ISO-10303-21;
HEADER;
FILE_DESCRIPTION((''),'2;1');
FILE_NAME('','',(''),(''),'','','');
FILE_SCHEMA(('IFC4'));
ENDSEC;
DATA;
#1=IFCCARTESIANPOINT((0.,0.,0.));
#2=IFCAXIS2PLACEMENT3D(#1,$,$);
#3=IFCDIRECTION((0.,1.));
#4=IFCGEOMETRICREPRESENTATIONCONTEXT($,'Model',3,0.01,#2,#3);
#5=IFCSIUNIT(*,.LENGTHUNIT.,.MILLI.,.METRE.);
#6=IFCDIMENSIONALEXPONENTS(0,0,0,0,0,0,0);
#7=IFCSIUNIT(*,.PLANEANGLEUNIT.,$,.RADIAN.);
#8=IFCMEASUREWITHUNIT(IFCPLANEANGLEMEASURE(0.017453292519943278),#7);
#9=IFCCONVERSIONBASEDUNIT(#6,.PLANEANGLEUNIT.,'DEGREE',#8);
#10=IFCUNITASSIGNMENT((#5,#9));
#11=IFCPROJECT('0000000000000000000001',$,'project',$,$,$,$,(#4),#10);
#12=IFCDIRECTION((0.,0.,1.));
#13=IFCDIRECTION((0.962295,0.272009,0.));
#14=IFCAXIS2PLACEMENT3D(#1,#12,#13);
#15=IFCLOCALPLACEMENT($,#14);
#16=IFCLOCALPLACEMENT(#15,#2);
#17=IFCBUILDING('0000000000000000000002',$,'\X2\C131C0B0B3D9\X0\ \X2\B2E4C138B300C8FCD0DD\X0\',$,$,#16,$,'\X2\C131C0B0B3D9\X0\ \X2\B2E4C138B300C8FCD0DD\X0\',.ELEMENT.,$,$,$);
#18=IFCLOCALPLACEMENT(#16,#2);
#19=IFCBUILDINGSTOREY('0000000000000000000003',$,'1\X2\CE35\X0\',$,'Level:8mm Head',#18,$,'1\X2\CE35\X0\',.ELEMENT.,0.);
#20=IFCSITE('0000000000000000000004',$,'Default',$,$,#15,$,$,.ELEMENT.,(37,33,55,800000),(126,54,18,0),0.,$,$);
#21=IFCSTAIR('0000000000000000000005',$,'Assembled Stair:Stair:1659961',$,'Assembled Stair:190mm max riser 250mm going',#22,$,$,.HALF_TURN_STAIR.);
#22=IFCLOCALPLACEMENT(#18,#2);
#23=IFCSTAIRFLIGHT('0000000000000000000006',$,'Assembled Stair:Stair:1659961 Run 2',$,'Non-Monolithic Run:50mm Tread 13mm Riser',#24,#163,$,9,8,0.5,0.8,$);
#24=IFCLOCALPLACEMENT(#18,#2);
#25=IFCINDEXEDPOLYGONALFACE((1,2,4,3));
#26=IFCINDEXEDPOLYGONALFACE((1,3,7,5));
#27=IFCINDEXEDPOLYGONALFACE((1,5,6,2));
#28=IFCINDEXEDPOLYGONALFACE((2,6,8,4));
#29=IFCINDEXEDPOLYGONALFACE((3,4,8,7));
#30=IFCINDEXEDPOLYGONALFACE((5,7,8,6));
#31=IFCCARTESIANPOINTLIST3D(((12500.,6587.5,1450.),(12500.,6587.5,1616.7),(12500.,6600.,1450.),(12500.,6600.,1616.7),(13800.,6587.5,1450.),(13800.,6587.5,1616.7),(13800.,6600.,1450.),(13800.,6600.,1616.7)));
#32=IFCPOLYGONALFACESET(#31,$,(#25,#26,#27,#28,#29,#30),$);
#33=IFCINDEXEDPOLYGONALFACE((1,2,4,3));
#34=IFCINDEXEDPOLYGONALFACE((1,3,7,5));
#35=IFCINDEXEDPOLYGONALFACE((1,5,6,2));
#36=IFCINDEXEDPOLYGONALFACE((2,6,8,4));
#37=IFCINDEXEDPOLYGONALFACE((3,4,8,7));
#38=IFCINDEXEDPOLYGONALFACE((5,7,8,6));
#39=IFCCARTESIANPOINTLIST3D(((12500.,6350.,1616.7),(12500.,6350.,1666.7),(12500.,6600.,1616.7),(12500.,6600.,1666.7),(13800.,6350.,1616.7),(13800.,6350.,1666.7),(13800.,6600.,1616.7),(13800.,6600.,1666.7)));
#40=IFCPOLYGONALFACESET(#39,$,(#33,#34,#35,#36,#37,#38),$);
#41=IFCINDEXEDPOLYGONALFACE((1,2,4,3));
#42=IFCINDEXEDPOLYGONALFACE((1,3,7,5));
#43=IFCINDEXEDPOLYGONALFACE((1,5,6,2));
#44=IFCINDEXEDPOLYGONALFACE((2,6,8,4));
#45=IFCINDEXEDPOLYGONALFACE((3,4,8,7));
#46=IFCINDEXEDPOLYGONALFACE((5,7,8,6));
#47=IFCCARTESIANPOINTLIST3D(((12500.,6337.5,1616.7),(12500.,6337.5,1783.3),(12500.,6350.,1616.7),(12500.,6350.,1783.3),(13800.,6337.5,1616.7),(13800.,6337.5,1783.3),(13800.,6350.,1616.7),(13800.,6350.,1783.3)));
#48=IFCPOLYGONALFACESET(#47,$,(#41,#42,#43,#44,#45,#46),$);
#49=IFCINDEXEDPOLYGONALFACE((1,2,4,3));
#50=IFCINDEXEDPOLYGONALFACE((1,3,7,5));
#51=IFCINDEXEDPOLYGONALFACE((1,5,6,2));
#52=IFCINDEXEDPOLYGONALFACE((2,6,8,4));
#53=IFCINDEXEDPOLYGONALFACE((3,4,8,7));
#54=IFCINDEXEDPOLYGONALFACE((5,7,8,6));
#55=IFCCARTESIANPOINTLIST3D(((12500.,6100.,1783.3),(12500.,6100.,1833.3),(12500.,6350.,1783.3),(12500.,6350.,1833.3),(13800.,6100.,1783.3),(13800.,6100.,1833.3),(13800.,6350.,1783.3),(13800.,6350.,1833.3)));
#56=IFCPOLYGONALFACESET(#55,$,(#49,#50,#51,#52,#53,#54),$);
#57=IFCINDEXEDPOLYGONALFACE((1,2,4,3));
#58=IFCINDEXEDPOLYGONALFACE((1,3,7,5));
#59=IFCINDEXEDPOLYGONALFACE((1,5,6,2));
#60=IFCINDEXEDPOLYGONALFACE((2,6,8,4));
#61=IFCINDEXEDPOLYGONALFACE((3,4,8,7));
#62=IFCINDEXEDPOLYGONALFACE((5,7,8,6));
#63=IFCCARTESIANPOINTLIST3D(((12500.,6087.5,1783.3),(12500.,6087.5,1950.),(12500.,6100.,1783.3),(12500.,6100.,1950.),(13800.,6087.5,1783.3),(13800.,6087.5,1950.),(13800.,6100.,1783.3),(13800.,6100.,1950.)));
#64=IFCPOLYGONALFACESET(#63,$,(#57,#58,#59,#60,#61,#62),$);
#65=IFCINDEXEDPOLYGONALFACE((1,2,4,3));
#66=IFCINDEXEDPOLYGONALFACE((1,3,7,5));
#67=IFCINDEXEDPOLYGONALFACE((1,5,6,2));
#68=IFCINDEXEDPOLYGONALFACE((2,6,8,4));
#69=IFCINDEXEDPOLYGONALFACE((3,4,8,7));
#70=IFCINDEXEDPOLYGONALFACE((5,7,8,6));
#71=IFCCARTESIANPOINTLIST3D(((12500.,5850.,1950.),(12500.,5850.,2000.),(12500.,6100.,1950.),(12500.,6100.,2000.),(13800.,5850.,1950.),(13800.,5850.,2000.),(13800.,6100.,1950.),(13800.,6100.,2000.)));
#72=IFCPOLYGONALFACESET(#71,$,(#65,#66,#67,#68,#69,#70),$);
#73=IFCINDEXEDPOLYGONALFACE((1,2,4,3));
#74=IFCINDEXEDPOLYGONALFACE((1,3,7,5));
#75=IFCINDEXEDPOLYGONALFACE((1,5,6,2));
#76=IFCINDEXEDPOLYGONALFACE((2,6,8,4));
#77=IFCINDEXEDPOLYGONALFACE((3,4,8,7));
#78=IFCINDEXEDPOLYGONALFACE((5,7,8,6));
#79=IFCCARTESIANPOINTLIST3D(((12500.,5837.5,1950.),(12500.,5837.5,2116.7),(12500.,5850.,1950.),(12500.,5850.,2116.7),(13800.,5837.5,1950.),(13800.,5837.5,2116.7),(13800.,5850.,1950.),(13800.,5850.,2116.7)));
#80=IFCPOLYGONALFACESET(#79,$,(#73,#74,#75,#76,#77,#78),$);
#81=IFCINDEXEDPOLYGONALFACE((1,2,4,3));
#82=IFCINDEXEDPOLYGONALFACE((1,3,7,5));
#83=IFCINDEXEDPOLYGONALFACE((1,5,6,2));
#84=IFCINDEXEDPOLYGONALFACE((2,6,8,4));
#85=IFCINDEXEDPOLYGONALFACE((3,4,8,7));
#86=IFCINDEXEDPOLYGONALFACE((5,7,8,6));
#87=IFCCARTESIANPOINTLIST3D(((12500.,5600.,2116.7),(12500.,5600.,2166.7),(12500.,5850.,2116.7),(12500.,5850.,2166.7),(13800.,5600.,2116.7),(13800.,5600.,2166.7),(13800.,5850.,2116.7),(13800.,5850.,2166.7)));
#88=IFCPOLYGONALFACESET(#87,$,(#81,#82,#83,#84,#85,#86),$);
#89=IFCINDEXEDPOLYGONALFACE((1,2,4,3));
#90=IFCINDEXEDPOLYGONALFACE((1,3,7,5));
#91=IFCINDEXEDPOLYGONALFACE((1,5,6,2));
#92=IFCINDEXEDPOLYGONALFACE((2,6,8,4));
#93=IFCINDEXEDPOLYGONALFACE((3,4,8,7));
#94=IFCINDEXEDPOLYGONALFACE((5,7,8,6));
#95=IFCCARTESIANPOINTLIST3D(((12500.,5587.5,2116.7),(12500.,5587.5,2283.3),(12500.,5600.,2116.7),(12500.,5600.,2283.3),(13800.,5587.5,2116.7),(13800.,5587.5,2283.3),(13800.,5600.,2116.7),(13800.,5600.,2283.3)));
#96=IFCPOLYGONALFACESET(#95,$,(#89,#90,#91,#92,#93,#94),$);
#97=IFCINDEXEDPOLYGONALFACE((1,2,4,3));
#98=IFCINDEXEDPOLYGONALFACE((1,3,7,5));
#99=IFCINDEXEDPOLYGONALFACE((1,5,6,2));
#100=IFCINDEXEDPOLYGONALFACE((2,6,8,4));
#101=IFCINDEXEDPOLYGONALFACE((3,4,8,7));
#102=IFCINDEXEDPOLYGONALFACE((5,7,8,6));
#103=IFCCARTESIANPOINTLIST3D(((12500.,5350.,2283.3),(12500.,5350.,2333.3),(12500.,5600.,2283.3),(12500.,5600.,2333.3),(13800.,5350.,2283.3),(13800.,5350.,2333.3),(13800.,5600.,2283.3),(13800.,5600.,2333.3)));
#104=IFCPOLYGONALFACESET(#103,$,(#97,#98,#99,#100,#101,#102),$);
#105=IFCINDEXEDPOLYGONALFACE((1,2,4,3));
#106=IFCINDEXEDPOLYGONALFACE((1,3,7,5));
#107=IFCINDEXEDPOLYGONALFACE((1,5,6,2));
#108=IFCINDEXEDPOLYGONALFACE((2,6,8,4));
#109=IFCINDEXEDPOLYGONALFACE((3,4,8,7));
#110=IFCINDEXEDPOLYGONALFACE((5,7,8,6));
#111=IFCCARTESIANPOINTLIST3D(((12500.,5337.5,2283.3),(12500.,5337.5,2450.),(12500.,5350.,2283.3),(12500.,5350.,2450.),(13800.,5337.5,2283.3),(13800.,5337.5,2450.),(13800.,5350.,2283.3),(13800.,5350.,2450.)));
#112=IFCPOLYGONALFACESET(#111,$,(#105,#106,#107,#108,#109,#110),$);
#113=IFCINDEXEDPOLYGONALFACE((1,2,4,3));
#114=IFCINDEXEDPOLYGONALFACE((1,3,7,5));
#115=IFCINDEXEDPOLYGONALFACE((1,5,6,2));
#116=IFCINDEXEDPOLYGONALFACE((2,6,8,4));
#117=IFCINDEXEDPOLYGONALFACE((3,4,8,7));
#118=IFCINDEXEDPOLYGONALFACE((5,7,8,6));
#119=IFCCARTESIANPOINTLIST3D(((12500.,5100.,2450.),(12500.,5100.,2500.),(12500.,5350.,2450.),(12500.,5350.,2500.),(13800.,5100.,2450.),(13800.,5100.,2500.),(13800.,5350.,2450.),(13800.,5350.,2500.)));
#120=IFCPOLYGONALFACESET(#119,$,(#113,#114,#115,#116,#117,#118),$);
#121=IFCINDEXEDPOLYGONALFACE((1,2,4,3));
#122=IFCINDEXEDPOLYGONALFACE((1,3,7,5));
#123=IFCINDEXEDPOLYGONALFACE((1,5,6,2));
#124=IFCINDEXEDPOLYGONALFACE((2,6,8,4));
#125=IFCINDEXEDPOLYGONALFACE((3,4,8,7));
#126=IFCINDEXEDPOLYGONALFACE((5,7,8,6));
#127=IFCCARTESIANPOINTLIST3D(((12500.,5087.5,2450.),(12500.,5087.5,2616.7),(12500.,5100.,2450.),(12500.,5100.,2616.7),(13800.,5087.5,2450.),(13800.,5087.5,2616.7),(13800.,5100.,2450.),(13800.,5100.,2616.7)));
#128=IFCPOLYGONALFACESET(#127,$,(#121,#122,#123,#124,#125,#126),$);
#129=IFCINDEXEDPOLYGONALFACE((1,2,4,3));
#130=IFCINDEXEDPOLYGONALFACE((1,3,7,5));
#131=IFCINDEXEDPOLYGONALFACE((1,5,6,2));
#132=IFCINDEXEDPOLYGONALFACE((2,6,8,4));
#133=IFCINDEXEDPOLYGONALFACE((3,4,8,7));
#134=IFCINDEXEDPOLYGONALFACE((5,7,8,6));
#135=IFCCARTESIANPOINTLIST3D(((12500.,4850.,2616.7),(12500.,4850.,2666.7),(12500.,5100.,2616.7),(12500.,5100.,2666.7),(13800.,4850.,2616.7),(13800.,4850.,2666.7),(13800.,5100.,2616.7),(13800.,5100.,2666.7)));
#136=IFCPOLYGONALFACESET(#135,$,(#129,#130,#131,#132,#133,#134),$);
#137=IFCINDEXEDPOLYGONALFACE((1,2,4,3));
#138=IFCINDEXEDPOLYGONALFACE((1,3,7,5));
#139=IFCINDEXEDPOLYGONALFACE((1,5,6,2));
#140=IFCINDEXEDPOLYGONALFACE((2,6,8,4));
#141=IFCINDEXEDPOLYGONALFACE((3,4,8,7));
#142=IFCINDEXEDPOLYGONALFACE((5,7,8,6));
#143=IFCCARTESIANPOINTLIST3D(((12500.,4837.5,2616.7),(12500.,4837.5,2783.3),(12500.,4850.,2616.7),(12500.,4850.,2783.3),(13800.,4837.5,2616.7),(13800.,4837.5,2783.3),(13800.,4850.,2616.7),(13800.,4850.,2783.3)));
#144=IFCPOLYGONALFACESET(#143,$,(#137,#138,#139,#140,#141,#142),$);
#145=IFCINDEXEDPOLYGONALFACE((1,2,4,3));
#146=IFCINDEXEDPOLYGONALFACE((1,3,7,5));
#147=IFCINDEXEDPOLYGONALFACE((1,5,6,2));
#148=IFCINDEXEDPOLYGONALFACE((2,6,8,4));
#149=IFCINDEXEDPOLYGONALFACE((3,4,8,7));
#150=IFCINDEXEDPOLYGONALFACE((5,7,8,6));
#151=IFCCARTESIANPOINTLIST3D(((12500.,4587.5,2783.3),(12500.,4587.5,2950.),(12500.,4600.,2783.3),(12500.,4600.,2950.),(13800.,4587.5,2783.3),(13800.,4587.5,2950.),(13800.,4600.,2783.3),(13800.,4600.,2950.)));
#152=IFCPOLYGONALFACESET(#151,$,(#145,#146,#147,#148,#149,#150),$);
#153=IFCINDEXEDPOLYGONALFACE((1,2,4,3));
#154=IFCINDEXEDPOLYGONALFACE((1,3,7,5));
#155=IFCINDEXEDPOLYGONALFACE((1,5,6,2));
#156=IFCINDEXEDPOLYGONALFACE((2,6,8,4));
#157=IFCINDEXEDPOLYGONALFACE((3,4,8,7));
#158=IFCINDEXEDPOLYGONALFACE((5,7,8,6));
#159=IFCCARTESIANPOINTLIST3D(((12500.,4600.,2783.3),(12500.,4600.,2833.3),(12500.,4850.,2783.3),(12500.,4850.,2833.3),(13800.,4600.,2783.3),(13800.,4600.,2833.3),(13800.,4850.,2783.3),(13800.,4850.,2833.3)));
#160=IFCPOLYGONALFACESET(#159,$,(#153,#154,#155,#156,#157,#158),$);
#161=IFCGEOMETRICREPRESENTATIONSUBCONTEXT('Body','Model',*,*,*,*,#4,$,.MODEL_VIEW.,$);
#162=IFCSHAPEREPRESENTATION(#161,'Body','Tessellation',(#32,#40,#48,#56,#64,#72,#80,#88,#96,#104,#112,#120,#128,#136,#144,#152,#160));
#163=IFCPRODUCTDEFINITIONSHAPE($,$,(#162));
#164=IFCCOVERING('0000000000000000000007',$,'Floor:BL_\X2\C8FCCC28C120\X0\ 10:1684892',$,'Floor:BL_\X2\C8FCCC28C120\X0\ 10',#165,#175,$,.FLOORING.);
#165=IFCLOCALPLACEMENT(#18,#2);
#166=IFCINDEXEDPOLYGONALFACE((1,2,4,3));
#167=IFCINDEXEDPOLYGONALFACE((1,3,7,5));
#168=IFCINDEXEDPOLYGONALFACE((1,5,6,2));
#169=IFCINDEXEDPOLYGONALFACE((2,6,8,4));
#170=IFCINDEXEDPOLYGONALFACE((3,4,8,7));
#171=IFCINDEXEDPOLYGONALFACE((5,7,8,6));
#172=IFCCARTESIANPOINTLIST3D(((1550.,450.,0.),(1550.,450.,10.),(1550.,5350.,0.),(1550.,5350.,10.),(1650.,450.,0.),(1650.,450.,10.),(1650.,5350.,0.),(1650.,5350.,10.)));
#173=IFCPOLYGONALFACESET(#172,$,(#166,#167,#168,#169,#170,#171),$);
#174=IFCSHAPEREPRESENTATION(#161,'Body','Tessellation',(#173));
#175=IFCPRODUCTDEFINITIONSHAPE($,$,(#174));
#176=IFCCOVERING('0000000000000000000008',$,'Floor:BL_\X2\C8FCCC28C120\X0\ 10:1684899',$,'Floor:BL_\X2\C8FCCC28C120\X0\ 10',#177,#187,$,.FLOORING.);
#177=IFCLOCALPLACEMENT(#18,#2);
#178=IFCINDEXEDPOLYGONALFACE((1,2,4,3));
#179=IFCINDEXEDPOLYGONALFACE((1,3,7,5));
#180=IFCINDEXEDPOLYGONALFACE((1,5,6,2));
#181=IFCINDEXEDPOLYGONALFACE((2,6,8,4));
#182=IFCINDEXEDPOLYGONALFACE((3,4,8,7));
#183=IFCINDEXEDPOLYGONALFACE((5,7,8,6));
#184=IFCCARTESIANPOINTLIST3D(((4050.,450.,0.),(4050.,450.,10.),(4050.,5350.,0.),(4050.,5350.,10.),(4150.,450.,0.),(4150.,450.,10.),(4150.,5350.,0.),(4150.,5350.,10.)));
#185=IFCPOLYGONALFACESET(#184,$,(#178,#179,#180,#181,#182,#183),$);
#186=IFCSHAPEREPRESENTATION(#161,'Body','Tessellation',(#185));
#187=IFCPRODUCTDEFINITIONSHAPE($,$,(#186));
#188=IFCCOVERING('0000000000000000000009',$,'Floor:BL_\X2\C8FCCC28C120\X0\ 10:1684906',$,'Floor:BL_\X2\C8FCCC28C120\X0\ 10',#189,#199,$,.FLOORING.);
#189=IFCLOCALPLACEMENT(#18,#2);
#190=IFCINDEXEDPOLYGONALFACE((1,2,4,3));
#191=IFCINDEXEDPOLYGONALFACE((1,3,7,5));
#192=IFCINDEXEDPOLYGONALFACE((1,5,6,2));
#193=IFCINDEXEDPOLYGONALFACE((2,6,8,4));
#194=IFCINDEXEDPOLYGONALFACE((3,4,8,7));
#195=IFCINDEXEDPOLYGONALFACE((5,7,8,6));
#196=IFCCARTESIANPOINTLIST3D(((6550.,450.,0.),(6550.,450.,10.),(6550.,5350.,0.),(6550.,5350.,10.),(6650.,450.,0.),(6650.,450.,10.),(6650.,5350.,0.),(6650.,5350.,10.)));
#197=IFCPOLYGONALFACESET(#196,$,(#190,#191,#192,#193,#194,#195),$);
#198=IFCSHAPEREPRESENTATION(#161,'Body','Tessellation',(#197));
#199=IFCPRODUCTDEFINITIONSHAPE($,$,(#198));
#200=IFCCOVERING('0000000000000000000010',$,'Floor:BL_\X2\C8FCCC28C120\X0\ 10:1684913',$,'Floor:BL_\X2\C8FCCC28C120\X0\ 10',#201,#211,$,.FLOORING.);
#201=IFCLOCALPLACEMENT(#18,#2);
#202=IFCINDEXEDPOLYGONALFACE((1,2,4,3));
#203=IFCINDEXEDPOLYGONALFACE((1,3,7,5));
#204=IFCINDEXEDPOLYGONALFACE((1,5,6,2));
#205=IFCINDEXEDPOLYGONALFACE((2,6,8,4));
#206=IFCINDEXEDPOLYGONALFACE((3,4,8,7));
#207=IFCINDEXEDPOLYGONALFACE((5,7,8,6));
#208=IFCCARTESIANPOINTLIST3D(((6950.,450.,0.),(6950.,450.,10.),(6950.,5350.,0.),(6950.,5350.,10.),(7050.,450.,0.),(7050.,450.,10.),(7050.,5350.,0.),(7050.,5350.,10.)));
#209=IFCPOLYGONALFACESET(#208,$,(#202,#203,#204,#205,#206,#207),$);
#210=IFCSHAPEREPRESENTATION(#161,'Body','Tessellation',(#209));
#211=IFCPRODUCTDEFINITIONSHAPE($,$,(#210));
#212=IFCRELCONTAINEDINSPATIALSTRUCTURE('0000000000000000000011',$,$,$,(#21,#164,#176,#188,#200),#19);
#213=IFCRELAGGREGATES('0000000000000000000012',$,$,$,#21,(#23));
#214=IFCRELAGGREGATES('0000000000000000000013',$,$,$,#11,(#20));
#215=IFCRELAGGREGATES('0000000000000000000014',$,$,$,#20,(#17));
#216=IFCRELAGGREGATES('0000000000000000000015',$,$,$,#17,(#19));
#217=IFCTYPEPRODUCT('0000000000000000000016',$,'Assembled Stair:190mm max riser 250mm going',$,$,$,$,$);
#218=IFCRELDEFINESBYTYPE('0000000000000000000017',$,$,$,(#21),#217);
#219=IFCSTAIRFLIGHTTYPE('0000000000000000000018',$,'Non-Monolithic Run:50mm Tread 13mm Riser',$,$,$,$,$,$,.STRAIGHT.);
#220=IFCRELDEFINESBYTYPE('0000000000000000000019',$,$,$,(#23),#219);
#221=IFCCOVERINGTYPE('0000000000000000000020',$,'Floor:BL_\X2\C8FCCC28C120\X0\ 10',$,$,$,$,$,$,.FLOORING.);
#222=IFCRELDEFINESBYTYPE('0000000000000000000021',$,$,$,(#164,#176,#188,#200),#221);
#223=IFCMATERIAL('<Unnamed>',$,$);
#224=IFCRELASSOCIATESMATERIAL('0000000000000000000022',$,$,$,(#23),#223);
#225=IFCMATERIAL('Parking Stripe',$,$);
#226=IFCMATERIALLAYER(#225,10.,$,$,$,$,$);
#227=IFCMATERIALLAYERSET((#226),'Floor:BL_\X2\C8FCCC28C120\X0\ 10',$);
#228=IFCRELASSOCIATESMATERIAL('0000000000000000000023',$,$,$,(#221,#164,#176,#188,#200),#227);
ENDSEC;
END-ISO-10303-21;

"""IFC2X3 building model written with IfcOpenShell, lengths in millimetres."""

from ifc_helpers import new_model, entity, si_unit, converted_unit, direction, frame, frame_2d, origin, origin_2d_with_axis, place, context, subcontext, project, spatial, rectangle, extrude, material, layer, layer_set, layer_usage, type_object, element, aggregate, save


model = new_model("IFC2X3")

# Units and contexts
model_context = context("Model", 3, precision=0.01, world=origin(), true_north=direction((0.0, 1.0)))
body_context = subcontext(model_context, "Body", "Model", "MODEL_VIEW")
ifc_project = project(units=[si_unit("LENGTHUNIT", "METRE", prefix="MILLI"), converted_unit("PLANEANGLEUNIT", "DEGREE", entity("IfcPlaneAngleMeasure", 0.017453292519943278), si_unit("PLANEANGLEUNIT", "RADIAN"), dimensions=[0, 0, 0, 0, 0, 0, 0])], contexts=[model_context])

# Site, building, storey
site_placement = place(None, frame((0.0, 0.0, 0.0), z_axis=(0.0, 0.0, 1.0), x_axis=(0.962295, 0.272009, 0.0)))
site = spatial("IfcSite", under=ifc_project, at=site_placement, Name="Default", CompositionType="ELEMENT", RefLatitude=(37, 33, 55, 800000), RefLongitude=(126, 54, 18, 0), RefElevation=0.0)
building_placement = place(site_placement, origin())
building = spatial("IfcBuilding", under=site, at=building_placement, Name="성산동 다세대주택", LongName="성산동 다세대주택", CompositionType="ELEMENT")
storey_placement = place(building_placement, origin())
storey = spatial("IfcBuildingStorey", under=building, at=storey_placement, Name="1층", ObjectType="Level:8mm Head", LongName="1층", CompositionType="ELEMENT", Elevation=0.0)

# Stair
type_product = type_object("IfcTypeProduct", Name="Assembled Stair:190mm max riser 250mm going")
stair_placement = place(storey_placement, origin())
stair = element("IfcStair", 1, at=stair_placement, inside=storey, type_object=type_product, Name="Assembled Stair:Stair:1659961", ObjectType="Assembled Stair:190mm max riser 250mm going", ShapeType="HALF_TURN_STAIR")
ifc_material_1 = material(Name="<Unnamed>")

# Stair flight
stair_flight_type = type_object("IfcStairFlightType", Name="Non-Monolithic Run:50mm Tread 13mm Riser", PredefinedType="STRAIGHT")
stair_flight_1_placement = place(stair_placement, origin())
stair_flight_1 = element("IfcStairFlight", 2, at=stair_flight_1_placement, type_object=stair_flight_type, material=ifc_material_1, Name="Assembled Stair:Stair:1659961 Run 2", ObjectType="Non-Monolithic Run:50mm Tread 13mm Riser", NumberOfRiser=9, NumberOfTreads=8, RiserHeight=0.5, TreadLength=0.8, context=body_context, shape_type="SweptSolid", body=[
    extrude(rectangle(XDim=1300.0, YDim=12.5, at=frame_2d((0.0, 0.0), x_axis=(1.0, 0.0))), frame((13150.0, 6593.8, 1450.0)), (0.0, 0.0, 1.0), 166.7),
    extrude(rectangle(XDim=250.0, YDim=1300.0, at=origin_2d_with_axis()), frame((13150.0, 6475.0, 1616.7), z_axis=(0.0, 0.0, 1.0), x_axis=(0.0, 1.0, 0.0)), (0.0, 0.0, 1.0), 50.0),
    extrude(rectangle(XDim=1300.0, YDim=12.5, at=frame_2d((0.0, 0.0), x_axis=(1.0, 0.0))), frame((13150.0, 6343.8, 1616.7)), (0.0, 0.0, 1.0), 166.7),
    extrude(rectangle(XDim=250.0, YDim=1300.0, at=frame_2d((0.0, 0.0), x_axis=(1.0, 0.0))), frame((13150.0, 6225.0, 1783.3), z_axis=(0.0, 0.0, 1.0), x_axis=(0.0, 1.0, 0.0)), (0.0, 0.0, 1.0), 50.0),
    extrude(rectangle(XDim=1300.0, YDim=12.5, at=frame_2d((0.0, 0.0), x_axis=(1.0, 0.0))), frame((13150.0, 6093.8, 1783.3)), (0.0, 0.0, 1.0), 166.7),
    extrude(rectangle(XDim=250.0, YDim=1300.0, at=frame_2d((0.0, 0.0), x_axis=(1.0, 0.0))), frame((13150.0, 5975.0, 1950.0), z_axis=(0.0, 0.0, 1.0), x_axis=(0.0, 1.0, 0.0)), (0.0, 0.0, 1.0), 50.0),
    extrude(rectangle(XDim=1300.0, YDim=12.5, at=frame_2d((0.0, 0.0), x_axis=(1.0, 0.0))), frame((13150.0, 5843.8, 1950.0)), (0.0, 0.0, 1.0), 166.7),
    extrude(rectangle(XDim=250.0, YDim=1300.0, at=frame_2d((0.0, 0.0), x_axis=(1.0, 0.0))), frame((13150.0, 5725.0, 2116.7), z_axis=(0.0, 0.0, 1.0), x_axis=(0.0, 1.0, 0.0)), (0.0, 0.0, 1.0), 50.0),
    extrude(rectangle(XDim=1300.0, YDim=12.5, at=frame_2d((0.0, 0.0), x_axis=(1.0, 0.0))), frame((13150.0, 5593.8, 2116.7)), (0.0, 0.0, 1.0), 166.7),
    extrude(rectangle(XDim=250.0, YDim=1300.0, at=frame_2d((0.0, 0.0), x_axis=(1.0, 0.0))), frame((13150.0, 5475.0, 2283.3), z_axis=(0.0, 0.0, 1.0), x_axis=(0.0, 1.0, 0.0)), (0.0, 0.0, 1.0), 50.0),
    extrude(rectangle(XDim=1300.0, YDim=12.5, at=frame_2d((0.0, 0.0), x_axis=(1.0, 0.0))), frame((13150.0, 5343.8, 2283.3)), (0.0, 0.0, 1.0), 166.7),
    extrude(rectangle(XDim=250.0, YDim=1300.0, at=frame_2d((0.0, 0.0), x_axis=(1.0, 0.0))), frame((13150.0, 5225.0, 2450.0), z_axis=(0.0, 0.0, 1.0), x_axis=(0.0, 1.0, 0.0)), (0.0, 0.0, 1.0), 50.0),
    extrude(rectangle(XDim=1300.0, YDim=12.5, at=frame_2d((0.0, 0.0), x_axis=(1.0, 0.0))), frame((13150.0, 5093.8, 2450.0)), (0.0, 0.0, 1.0), 166.7),
    extrude(rectangle(XDim=250.0, YDim=1300.0, at=frame_2d((0.0, 0.0), x_axis=(1.0, 0.0))), frame((13150.0, 4975.0, 2616.7), z_axis=(0.0, 0.0, 1.0), x_axis=(0.0, 1.0, 0.0)), (0.0, 0.0, 1.0), 50.0),
    extrude(rectangle(XDim=1300.0, YDim=12.5, at=frame_2d((0.0, 0.0), x_axis=(1.0, 0.0))), frame((13150.0, 4843.8, 2616.7)), (0.0, 0.0, 1.0), 166.7),
    extrude(rectangle(XDim=1300.0, YDim=12.5, at=frame_2d((0.0, 0.0), x_axis=(1.0, 0.0))), frame((13150.0, 4593.8, 2783.3)), (0.0, 0.0, 1.0), 166.7),
    extrude(rectangle(XDim=250.0, YDim=1300.0, at=origin_2d_with_axis()), frame((13150.0, 4725.0, 2783.3), z_axis=(0.0, 0.0, 1.0), x_axis=(0.0, 1.0, 0.0)), (0.0, 0.0, 1.0), 50.0),
])
aggregate(stair, [stair_flight_1])

# Coverings
ifc_material_2 = material(Name="Parking Stripe")
ifc_layer_1 = layer(ifc_material_2, 10.0)
ifc_layer_set_1 = layer_set([ifc_layer_1], Name="Floor:BL_주차선 10")
ifc_layer_usage_1 = layer_usage(ifc_layer_set_1, "AXIS3", "POSITIVE", 0.0)
covering_type = type_object("IfcCoveringType", Name="Floor:BL_주차선 10", PredefinedType="FLOORING", material=ifc_layer_set_1)
covering_1_placement = place(storey_placement, origin())
element("IfcCovering", 3, at=covering_1_placement, inside=storey, type_object=covering_type, material=ifc_layer_usage_1, Name="Floor:BL_주차선 10:1684892", ObjectType="Floor:BL_주차선 10", PredefinedType="FLOORING", context=body_context, shape_type="SweptSolid", body=[
    extrude(rectangle(XDim=4900.0, YDim=100.0, at=origin_2d_with_axis()), frame((1600.0, 2900.0, 10.0), z_axis=(0.0, 0.0, -1.0), x_axis=(0.0, 1.0, 0.0)), (0.0, 0.0, 1.0), 10.0),
])
ifc_layer_usage_2 = layer_usage(ifc_layer_set_1, "AXIS3", "POSITIVE", 0.0)
covering_2_placement = place(storey_placement, origin())
element("IfcCovering", 4, at=covering_2_placement, inside=storey, type_object=covering_type, material=ifc_layer_usage_2, Name="Floor:BL_주차선 10:1684899", ObjectType="Floor:BL_주차선 10", PredefinedType="FLOORING", context=body_context, shape_type="SweptSolid", body=[
    extrude(rectangle(XDim=4900.0, YDim=100.0, at=frame_2d((0.0, 0.0), x_axis=(1.0, 0.0))), frame((4100.0, 2900.0, 10.0), z_axis=(0.0, 0.0, -1.0), x_axis=(0.0, 1.0, 0.0)), (0.0, 0.0, 1.0), 10.0),
])
ifc_layer_usage_3 = layer_usage(ifc_layer_set_1, "AXIS3", "POSITIVE", 0.0)
covering_3_placement = place(storey_placement, origin())
element("IfcCovering", 5, at=covering_3_placement, inside=storey, type_object=covering_type, material=ifc_layer_usage_3, Name="Floor:BL_주차선 10:1684906", ObjectType="Floor:BL_주차선 10", PredefinedType="FLOORING", context=body_context, shape_type="SweptSolid", body=[
    extrude(rectangle(XDim=4900.0, YDim=100.0, at=frame_2d((0.0, 0.0), x_axis=(1.0, 0.0))), frame((6600.0, 2900.0, 10.0), z_axis=(0.0, 0.0, -1.0), x_axis=(0.0, 1.0, 0.0)), (0.0, 0.0, 1.0), 10.0),
])
ifc_layer_usage_4 = layer_usage(ifc_layer_set_1, "AXIS3", "POSITIVE", 0.0)
covering_4_placement = place(storey_placement, origin())
element("IfcCovering", 6, at=covering_4_placement, inside=storey, type_object=covering_type, material=ifc_layer_usage_4, Name="Floor:BL_주차선 10:1684913", ObjectType="Floor:BL_주차선 10", PredefinedType="FLOORING", context=body_context, shape_type="SweptSolid", body=[
    extrude(rectangle(XDim=4900.0, YDim=100.0, at=frame_2d((0.0, 0.0), x_axis=(1.0, 0.0))), frame((7000.0, 2900.0, 10.0), z_axis=(0.0, 0.0, -1.0), x_axis=(0.0, 1.0, 0.0)), (0.0, 0.0, 1.0), 10.0),
])

save(model, "model.ifc")
